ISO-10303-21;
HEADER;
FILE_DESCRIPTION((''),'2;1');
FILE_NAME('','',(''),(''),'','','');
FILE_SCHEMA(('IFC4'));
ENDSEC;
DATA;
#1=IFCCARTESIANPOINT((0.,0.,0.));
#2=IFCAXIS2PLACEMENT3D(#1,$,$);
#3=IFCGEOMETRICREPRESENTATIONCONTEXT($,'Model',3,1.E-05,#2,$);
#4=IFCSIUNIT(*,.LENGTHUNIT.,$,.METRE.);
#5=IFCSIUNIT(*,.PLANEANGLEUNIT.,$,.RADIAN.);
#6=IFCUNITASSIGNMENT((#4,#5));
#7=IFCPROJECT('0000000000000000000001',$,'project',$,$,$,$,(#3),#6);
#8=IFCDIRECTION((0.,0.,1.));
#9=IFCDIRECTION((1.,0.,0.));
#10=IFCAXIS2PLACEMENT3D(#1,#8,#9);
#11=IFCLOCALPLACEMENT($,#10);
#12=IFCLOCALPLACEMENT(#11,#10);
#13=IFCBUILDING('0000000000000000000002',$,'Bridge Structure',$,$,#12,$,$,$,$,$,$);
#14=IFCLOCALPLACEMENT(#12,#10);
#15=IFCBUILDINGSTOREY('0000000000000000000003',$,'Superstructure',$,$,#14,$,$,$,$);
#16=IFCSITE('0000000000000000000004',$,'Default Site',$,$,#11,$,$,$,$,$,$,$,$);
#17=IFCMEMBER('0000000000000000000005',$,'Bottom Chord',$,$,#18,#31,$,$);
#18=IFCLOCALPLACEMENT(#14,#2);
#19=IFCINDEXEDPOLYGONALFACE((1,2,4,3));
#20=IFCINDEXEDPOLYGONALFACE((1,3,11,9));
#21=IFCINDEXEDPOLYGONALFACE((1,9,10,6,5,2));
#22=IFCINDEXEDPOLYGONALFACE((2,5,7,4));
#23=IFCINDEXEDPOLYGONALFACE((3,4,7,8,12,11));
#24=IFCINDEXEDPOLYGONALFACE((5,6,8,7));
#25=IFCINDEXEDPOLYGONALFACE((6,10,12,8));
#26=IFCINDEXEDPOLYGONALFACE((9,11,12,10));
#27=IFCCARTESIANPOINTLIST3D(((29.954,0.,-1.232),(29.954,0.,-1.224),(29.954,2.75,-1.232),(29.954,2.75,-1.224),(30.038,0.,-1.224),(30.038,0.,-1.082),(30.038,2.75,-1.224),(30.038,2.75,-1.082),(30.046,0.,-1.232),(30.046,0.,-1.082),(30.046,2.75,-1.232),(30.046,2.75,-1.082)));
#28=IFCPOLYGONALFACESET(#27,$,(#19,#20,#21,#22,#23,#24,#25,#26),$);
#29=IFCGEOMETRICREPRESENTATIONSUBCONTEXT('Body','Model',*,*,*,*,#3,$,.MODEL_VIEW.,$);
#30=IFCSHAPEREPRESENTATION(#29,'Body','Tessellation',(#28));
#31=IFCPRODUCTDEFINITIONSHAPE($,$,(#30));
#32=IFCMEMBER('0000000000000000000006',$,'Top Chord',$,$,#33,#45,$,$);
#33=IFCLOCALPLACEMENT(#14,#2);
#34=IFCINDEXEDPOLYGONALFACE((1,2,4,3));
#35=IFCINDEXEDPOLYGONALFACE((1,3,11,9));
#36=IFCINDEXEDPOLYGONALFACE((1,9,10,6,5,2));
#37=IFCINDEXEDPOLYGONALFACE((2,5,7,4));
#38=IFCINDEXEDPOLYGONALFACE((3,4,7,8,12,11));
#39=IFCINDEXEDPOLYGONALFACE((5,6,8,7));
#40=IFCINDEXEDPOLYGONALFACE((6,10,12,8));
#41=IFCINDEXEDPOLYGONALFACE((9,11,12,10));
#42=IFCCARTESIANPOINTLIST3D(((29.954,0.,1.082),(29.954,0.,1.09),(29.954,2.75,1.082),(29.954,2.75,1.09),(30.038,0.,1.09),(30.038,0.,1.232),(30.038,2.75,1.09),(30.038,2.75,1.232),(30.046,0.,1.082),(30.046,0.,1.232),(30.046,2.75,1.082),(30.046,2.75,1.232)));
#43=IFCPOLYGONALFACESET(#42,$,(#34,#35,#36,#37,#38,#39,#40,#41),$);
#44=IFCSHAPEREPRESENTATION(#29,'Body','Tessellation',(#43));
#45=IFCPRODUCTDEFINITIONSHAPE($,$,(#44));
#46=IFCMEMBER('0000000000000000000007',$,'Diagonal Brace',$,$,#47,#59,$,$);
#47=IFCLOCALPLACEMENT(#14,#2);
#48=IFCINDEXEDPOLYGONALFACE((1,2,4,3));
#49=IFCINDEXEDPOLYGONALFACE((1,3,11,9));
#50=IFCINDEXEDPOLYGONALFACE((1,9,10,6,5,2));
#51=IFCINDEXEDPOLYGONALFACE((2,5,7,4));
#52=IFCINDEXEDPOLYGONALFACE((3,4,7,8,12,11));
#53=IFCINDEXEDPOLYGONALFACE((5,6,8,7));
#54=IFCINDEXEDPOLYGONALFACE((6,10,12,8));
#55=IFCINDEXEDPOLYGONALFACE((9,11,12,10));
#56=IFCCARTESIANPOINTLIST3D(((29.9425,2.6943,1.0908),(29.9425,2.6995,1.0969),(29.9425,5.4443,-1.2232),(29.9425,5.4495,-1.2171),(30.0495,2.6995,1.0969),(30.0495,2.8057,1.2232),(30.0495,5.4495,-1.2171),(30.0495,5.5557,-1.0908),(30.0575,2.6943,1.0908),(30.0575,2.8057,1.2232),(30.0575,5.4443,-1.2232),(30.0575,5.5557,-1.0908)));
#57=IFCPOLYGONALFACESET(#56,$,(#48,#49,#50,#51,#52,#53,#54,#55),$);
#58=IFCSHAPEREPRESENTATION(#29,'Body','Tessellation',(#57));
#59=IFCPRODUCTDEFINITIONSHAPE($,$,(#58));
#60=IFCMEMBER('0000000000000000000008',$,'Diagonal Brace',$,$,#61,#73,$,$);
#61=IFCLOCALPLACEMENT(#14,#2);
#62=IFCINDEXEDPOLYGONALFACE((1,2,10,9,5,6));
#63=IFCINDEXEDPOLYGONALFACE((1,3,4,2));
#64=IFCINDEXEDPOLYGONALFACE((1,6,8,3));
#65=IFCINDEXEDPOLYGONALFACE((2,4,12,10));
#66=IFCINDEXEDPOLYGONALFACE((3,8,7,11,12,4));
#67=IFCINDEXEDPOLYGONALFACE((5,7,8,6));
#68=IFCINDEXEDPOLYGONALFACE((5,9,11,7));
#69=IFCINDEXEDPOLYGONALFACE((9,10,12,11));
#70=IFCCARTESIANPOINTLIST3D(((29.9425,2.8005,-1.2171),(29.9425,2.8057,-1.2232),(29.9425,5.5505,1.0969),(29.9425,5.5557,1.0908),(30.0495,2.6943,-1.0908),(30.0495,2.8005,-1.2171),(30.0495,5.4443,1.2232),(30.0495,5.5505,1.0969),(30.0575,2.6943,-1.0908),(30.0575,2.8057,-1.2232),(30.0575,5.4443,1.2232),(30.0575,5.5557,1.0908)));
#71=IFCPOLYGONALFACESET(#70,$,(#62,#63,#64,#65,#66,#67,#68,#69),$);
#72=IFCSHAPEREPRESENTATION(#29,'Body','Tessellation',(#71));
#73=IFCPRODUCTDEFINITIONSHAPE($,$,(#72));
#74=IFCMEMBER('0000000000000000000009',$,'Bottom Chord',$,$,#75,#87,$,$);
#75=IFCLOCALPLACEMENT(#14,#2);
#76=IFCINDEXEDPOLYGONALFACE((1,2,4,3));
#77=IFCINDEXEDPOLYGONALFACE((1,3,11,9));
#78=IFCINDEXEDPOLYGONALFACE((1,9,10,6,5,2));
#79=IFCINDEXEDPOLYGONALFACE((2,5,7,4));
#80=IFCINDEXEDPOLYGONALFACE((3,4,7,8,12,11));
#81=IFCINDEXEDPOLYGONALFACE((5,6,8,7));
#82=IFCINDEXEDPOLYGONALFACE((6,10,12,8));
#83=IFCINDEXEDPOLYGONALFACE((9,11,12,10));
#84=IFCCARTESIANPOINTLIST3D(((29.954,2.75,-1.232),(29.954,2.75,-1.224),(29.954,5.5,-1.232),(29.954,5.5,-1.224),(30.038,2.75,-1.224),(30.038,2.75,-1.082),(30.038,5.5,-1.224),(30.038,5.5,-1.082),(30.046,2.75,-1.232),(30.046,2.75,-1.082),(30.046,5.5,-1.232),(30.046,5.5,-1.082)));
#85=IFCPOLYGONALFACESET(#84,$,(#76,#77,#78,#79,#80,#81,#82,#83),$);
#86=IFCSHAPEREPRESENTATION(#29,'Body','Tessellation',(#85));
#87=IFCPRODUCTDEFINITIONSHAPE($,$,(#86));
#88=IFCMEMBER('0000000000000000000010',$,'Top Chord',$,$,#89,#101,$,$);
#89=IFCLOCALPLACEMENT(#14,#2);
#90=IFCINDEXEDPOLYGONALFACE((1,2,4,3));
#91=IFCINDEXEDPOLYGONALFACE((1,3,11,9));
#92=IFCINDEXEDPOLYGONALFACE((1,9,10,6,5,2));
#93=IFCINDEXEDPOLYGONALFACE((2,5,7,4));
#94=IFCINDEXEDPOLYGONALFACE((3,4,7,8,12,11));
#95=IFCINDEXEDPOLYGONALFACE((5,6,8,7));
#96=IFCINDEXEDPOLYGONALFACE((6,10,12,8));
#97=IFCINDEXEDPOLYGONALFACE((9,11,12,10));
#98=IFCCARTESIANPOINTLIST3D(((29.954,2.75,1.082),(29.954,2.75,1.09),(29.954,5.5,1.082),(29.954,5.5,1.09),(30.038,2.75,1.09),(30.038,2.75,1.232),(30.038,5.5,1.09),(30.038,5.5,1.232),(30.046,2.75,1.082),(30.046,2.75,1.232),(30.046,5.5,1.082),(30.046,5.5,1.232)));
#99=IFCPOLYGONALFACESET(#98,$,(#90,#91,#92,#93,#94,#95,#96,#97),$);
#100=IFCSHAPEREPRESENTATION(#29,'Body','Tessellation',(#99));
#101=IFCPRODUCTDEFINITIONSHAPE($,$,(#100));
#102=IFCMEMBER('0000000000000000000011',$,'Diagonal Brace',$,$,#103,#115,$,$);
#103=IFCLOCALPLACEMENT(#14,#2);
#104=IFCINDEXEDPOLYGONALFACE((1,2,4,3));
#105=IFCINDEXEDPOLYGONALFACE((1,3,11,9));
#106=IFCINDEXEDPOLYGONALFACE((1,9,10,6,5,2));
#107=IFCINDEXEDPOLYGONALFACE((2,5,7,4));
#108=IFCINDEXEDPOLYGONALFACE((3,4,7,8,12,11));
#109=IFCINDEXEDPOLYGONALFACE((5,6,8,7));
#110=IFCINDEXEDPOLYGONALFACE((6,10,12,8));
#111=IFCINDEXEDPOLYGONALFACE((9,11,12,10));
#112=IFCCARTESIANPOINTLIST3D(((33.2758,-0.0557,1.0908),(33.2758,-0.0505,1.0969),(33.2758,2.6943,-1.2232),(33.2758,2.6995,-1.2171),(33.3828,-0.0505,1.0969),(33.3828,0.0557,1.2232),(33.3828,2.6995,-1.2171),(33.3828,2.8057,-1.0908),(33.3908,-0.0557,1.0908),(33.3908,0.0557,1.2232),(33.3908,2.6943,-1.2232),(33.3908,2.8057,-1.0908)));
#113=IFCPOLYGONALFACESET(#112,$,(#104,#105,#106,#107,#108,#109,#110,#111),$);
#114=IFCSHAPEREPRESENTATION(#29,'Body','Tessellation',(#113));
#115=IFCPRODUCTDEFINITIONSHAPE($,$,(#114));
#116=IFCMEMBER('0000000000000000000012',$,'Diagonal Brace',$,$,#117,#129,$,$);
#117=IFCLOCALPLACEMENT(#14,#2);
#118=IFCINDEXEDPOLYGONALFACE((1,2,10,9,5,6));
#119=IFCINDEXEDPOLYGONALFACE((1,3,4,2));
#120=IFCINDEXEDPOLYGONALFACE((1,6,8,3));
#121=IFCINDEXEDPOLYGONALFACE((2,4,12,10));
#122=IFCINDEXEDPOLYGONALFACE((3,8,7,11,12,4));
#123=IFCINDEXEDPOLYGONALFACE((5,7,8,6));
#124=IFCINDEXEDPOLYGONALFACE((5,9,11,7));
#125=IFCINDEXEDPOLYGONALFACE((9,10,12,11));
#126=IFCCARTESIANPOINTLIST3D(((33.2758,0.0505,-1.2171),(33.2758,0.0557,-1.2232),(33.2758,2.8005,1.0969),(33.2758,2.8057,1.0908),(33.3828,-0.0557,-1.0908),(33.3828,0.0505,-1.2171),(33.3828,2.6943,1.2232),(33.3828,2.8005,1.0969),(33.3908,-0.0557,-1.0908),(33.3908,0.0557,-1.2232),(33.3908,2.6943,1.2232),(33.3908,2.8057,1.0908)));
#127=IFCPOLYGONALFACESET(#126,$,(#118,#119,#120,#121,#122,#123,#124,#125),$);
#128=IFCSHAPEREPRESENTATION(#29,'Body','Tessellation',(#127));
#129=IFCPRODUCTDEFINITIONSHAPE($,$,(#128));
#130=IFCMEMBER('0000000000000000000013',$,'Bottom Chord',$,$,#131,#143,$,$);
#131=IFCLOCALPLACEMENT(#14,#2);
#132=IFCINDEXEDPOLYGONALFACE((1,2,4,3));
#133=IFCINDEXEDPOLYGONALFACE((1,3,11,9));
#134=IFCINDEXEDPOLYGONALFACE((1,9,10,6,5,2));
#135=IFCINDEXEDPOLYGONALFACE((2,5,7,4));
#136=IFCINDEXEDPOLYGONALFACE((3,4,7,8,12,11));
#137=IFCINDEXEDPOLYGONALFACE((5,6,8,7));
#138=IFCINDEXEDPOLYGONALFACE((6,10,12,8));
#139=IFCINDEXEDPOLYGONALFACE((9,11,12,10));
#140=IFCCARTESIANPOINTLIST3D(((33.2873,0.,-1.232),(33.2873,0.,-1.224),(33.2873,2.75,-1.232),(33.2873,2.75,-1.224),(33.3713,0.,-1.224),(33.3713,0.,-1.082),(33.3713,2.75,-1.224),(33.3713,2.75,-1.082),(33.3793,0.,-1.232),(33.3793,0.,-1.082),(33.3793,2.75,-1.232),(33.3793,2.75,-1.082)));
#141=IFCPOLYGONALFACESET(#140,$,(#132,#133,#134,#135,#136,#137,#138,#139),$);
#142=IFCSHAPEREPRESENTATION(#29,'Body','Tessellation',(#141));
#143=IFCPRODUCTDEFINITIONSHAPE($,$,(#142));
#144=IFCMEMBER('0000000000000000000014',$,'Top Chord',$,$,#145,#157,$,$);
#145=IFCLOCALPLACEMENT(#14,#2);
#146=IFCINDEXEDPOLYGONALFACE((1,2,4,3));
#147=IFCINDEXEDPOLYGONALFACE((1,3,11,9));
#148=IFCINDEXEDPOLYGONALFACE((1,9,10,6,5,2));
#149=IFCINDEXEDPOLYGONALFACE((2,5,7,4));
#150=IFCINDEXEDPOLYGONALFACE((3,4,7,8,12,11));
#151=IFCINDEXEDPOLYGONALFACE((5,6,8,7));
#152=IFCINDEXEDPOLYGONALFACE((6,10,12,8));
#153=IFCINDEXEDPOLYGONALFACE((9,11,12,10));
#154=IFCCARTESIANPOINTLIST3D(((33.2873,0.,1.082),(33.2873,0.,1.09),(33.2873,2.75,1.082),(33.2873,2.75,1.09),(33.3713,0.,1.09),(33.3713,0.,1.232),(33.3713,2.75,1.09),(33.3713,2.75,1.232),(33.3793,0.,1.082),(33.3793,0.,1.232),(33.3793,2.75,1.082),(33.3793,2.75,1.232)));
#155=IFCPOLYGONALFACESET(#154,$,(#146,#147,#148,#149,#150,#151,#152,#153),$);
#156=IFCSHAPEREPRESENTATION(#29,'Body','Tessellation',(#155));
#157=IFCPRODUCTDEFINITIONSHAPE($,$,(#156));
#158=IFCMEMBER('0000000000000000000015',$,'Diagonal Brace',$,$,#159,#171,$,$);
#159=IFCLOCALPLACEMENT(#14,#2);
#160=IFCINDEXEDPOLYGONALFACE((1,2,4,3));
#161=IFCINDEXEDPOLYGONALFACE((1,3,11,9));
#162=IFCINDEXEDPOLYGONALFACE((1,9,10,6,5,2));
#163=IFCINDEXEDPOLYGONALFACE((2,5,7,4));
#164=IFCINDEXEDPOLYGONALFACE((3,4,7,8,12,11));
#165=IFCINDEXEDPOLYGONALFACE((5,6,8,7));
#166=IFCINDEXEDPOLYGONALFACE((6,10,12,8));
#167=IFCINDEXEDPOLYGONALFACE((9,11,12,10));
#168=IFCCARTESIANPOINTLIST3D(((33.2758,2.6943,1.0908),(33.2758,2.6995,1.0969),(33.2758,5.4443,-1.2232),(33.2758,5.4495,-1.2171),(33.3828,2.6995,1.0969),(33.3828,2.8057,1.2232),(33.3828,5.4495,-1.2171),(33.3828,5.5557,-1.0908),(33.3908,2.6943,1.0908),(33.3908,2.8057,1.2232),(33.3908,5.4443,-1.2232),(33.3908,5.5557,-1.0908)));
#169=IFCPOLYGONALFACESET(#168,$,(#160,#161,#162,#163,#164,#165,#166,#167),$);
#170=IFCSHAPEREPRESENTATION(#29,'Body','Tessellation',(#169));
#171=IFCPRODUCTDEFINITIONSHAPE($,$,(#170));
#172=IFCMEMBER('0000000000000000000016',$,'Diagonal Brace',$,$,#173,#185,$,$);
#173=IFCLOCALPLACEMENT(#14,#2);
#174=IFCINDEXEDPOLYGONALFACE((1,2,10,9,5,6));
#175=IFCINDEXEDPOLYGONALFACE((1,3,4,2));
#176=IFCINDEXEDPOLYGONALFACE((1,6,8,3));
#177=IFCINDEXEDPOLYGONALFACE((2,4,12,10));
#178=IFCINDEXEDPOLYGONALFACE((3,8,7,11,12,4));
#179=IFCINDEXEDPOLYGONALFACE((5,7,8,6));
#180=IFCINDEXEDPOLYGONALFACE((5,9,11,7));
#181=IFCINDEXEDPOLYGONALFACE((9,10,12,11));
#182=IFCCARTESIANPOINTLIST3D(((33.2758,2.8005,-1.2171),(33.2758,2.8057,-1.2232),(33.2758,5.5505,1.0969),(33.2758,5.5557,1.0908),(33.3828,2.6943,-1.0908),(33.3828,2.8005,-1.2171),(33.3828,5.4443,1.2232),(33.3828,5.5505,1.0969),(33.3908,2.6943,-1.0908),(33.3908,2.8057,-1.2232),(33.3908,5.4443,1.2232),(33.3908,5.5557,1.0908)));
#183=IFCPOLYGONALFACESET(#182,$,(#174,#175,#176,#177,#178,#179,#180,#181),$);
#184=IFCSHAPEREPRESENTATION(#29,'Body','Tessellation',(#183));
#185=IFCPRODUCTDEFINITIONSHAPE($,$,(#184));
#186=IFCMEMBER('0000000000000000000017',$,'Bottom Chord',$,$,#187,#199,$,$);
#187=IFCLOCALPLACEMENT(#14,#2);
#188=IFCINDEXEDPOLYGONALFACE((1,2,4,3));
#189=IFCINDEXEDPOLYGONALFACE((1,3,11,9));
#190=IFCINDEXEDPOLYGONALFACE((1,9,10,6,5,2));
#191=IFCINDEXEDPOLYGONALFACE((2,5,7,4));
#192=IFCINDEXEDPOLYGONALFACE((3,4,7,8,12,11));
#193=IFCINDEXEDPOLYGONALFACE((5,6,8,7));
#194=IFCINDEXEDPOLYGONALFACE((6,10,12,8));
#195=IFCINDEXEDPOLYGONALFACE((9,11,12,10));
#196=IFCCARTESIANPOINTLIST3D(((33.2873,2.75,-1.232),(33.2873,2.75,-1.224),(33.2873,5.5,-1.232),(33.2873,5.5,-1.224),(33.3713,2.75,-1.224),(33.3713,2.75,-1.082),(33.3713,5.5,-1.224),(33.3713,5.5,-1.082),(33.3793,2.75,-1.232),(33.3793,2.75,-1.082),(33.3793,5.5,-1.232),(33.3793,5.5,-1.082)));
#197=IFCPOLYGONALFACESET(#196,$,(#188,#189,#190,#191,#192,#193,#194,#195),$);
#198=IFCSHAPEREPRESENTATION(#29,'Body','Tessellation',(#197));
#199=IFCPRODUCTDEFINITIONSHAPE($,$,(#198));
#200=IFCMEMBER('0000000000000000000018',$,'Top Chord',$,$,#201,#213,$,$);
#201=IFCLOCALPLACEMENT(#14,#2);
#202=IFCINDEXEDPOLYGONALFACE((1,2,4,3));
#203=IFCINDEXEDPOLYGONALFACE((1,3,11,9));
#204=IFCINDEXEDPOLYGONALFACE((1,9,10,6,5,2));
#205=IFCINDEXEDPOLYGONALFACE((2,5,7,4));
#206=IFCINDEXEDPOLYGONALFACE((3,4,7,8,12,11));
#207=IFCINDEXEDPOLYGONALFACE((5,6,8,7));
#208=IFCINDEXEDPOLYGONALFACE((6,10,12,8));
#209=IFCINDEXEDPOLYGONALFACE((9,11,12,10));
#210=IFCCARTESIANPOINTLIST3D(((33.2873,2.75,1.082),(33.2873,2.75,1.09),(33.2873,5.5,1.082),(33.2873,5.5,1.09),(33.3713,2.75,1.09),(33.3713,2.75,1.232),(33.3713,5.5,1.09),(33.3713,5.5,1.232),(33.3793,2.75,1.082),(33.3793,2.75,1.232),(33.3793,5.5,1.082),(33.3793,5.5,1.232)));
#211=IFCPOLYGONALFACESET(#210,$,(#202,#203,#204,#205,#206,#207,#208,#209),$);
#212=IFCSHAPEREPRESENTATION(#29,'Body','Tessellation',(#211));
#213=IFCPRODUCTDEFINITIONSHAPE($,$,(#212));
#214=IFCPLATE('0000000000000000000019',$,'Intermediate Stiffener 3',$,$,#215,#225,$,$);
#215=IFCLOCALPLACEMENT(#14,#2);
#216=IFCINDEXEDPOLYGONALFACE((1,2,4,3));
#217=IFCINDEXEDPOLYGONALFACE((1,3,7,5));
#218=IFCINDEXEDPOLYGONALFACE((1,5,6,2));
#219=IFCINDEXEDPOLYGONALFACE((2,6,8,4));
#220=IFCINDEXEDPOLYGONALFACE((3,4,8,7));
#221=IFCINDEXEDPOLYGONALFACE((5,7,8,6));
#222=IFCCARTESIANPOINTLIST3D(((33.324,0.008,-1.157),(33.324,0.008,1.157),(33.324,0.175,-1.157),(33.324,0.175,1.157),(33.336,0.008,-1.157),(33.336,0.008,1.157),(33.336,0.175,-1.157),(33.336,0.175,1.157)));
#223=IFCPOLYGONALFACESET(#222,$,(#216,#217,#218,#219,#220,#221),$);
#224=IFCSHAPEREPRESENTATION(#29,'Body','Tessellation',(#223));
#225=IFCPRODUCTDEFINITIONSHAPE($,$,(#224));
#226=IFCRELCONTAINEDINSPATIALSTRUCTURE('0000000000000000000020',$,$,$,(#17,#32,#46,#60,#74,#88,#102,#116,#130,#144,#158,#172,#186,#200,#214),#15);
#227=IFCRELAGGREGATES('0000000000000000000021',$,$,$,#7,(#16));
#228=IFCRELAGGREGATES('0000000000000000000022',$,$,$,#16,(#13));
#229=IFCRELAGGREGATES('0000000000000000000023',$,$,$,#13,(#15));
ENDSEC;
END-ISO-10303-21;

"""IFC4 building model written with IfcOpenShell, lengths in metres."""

from ifc_helpers import new_model, si_unit, frame, origin, origin_with_axes, origin_2d_with_axis, place, context, subcontext, project, spatial, rectangle, l_section, extrude, element, save


model = new_model("IFC4")

# Units and contexts
model_context = context("Model", 3, precision=1e-05, world=origin())
body_context = subcontext(model_context, "Body", "Model", "MODEL_VIEW")
ifc_project = project(units=[si_unit("LENGTHUNIT", "METRE"), si_unit("PLANEANGLEUNIT", "RADIAN")], contexts=[model_context])

# Site, building, storey
site_placement = place(None, origin_with_axes())
site = spatial("IfcSite", under=ifc_project, at=site_placement, Name="Default Site")
building_placement = place(site_placement, origin_with_axes())
building = spatial("IfcBuilding", under=site, at=building_placement, Name="Bridge Structure")
storey_placement = place(building_placement, origin_with_axes())
storey = spatial("IfcBuildingStorey", under=building, at=storey_placement, Name="Superstructure")

# Members
for number, where, z_axis, x_axis, name in (
    (1, (30.0, 0.0, -1.157), (0.0, 1.0, 0.0), (-1.0, 0.0, 0.0), "Bottom Chord"),
    (2, (30.0, 0.0, 1.157), (0.0, 1.0, 0.0), (-1.0, 0.0, 0.0), "Top Chord"),
):
    element("IfcMember", number, at=place(storey_placement, frame(where, z_axis=z_axis, x_axis=x_axis)), inside=storey, Name=name, context=body_context, shape_type="SweptSolid", body=[
        extrude(l_section(Depth=0.15, Width=0.092, Thickness=0.008, at=origin_2d_with_axis()), origin_with_axes(), (0.0, 0.0, 1.0), 2.75),
    ])
for number, where, z_axis, x_axis, name in (
    (3, (30.0, 2.75, 1.157), (0.0, 0.765156, -0.643844), (-1.0, 0.0, 0.0), "Diagonal Brace"),
    (4, (30.0, 2.75, -1.157), (0.0, 0.765156, 0.643844), (-1.0, 0.0, 0.0), "Diagonal Brace"),
):
    element("IfcMember", number, at=place(storey_placement, frame(where, z_axis=z_axis, x_axis=x_axis)), inside=storey, Name=name, context=body_context, shape_type="SweptSolid", body=[
        extrude(l_section(Depth=0.173, Width=0.115, Thickness=0.008, at=origin_2d_with_axis()), origin_with_axes(), (0.0, 0.0, 1.0), 3.594),
    ])
for number, where, z_axis, x_axis, name in (
    (5, (30.0, 2.75, -1.157), (0.0, 1.0, 0.0), (-1.0, 0.0, 0.0), "Bottom Chord"),
    (6, (30.0, 2.75, 1.157), (0.0, 1.0, 0.0), (-1.0, 0.0, 0.0), "Top Chord"),
):
    element("IfcMember", number, at=place(storey_placement, frame(where, z_axis=z_axis, x_axis=x_axis)), inside=storey, Name=name, context=body_context, shape_type="SweptSolid", body=[
        extrude(l_section(Depth=0.15, Width=0.092, Thickness=0.008, at=origin_2d_with_axis()), origin_with_axes(), (0.0, 0.0, 1.0), 2.75),
    ])
for number, where, z_axis, x_axis, name in (
    (7, (33.3333, 0.0, 1.157), (0.0, 0.765156, -0.643844), (-1.0, 0.0, 0.0), "Diagonal Brace"),
    (8, (33.3333, 0.0, -1.157), (0.0, 0.765156, 0.643844), (-1.0, 0.0, 0.0), "Diagonal Brace"),
):
    element("IfcMember", number, at=place(storey_placement, frame(where, z_axis=z_axis, x_axis=x_axis)), inside=storey, Name=name, context=body_context, shape_type="SweptSolid", body=[
        extrude(l_section(Depth=0.173, Width=0.115, Thickness=0.008, at=origin_2d_with_axis()), origin_with_axes(), (0.0, 0.0, 1.0), 3.594),
    ])
for number, where, z_axis, x_axis, name in (
    (9, (33.3333, 0.0, -1.157), (0.0, 1.0, 0.0), (-1.0, 0.0, 0.0), "Bottom Chord"),
    (10, (33.3333, 0.0, 1.157), (0.0, 1.0, 0.0), (-1.0, 0.0, 0.0), "Top Chord"),
):
    element("IfcMember", number, at=place(storey_placement, frame(where, z_axis=z_axis, x_axis=x_axis)), inside=storey, Name=name, context=body_context, shape_type="SweptSolid", body=[
        extrude(l_section(Depth=0.15, Width=0.092, Thickness=0.008, at=origin_2d_with_axis()), origin_with_axes(), (0.0, 0.0, 1.0), 2.75),
    ])
for number, where, z_axis, x_axis, name in (
    (11, (33.3333, 2.75, 1.157), (0.0, 0.765156, -0.643844), (-1.0, 0.0, 0.0), "Diagonal Brace"),
    (12, (33.3333, 2.75, -1.157), (0.0, 0.765156, 0.643844), (-1.0, 0.0, 0.0), "Diagonal Brace"),
):
    element("IfcMember", number, at=place(storey_placement, frame(where, z_axis=z_axis, x_axis=x_axis)), inside=storey, Name=name, context=body_context, shape_type="SweptSolid", body=[
        extrude(l_section(Depth=0.173, Width=0.115, Thickness=0.008, at=origin_2d_with_axis()), origin_with_axes(), (0.0, 0.0, 1.0), 3.594),
    ])
for number, where, z_axis, x_axis, name in (
    (13, (33.3333, 2.75, -1.157), (0.0, 1.0, 0.0), (-1.0, 0.0, 0.0), "Bottom Chord"),
    (14, (33.3333, 2.75, 1.157), (0.0, 1.0, 0.0), (-1.0, 0.0, 0.0), "Top Chord"),
):
    element("IfcMember", number, at=place(storey_placement, frame(where, z_axis=z_axis, x_axis=x_axis)), inside=storey, Name=name, context=body_context, shape_type="SweptSolid", body=[
        extrude(l_section(Depth=0.15, Width=0.092, Thickness=0.008, at=origin_2d_with_axis()), origin_with_axes(), (0.0, 0.0, 1.0), 2.75),
    ])

# Plate
for number, where, z_axis, x_axis, name in (
    (15, (33.33, 0.0915, -1.157), (0.0, 0.0, 1.0), (1.0, 0.0, 0.0), "Intermediate Stiffener 3"),
):
    element("IfcPlate", number, at=place(storey_placement, frame(where, z_axis=z_axis, x_axis=x_axis)), inside=storey, Name=name, context=body_context, shape_type="SweptSolid", body=[
        extrude(rectangle(XDim=0.012, YDim=0.167, at=origin_2d_with_axis()), origin_with_axes(), (0.0, 0.0, 1.0), 2.314),
    ])

save(model, "model.ifc")
